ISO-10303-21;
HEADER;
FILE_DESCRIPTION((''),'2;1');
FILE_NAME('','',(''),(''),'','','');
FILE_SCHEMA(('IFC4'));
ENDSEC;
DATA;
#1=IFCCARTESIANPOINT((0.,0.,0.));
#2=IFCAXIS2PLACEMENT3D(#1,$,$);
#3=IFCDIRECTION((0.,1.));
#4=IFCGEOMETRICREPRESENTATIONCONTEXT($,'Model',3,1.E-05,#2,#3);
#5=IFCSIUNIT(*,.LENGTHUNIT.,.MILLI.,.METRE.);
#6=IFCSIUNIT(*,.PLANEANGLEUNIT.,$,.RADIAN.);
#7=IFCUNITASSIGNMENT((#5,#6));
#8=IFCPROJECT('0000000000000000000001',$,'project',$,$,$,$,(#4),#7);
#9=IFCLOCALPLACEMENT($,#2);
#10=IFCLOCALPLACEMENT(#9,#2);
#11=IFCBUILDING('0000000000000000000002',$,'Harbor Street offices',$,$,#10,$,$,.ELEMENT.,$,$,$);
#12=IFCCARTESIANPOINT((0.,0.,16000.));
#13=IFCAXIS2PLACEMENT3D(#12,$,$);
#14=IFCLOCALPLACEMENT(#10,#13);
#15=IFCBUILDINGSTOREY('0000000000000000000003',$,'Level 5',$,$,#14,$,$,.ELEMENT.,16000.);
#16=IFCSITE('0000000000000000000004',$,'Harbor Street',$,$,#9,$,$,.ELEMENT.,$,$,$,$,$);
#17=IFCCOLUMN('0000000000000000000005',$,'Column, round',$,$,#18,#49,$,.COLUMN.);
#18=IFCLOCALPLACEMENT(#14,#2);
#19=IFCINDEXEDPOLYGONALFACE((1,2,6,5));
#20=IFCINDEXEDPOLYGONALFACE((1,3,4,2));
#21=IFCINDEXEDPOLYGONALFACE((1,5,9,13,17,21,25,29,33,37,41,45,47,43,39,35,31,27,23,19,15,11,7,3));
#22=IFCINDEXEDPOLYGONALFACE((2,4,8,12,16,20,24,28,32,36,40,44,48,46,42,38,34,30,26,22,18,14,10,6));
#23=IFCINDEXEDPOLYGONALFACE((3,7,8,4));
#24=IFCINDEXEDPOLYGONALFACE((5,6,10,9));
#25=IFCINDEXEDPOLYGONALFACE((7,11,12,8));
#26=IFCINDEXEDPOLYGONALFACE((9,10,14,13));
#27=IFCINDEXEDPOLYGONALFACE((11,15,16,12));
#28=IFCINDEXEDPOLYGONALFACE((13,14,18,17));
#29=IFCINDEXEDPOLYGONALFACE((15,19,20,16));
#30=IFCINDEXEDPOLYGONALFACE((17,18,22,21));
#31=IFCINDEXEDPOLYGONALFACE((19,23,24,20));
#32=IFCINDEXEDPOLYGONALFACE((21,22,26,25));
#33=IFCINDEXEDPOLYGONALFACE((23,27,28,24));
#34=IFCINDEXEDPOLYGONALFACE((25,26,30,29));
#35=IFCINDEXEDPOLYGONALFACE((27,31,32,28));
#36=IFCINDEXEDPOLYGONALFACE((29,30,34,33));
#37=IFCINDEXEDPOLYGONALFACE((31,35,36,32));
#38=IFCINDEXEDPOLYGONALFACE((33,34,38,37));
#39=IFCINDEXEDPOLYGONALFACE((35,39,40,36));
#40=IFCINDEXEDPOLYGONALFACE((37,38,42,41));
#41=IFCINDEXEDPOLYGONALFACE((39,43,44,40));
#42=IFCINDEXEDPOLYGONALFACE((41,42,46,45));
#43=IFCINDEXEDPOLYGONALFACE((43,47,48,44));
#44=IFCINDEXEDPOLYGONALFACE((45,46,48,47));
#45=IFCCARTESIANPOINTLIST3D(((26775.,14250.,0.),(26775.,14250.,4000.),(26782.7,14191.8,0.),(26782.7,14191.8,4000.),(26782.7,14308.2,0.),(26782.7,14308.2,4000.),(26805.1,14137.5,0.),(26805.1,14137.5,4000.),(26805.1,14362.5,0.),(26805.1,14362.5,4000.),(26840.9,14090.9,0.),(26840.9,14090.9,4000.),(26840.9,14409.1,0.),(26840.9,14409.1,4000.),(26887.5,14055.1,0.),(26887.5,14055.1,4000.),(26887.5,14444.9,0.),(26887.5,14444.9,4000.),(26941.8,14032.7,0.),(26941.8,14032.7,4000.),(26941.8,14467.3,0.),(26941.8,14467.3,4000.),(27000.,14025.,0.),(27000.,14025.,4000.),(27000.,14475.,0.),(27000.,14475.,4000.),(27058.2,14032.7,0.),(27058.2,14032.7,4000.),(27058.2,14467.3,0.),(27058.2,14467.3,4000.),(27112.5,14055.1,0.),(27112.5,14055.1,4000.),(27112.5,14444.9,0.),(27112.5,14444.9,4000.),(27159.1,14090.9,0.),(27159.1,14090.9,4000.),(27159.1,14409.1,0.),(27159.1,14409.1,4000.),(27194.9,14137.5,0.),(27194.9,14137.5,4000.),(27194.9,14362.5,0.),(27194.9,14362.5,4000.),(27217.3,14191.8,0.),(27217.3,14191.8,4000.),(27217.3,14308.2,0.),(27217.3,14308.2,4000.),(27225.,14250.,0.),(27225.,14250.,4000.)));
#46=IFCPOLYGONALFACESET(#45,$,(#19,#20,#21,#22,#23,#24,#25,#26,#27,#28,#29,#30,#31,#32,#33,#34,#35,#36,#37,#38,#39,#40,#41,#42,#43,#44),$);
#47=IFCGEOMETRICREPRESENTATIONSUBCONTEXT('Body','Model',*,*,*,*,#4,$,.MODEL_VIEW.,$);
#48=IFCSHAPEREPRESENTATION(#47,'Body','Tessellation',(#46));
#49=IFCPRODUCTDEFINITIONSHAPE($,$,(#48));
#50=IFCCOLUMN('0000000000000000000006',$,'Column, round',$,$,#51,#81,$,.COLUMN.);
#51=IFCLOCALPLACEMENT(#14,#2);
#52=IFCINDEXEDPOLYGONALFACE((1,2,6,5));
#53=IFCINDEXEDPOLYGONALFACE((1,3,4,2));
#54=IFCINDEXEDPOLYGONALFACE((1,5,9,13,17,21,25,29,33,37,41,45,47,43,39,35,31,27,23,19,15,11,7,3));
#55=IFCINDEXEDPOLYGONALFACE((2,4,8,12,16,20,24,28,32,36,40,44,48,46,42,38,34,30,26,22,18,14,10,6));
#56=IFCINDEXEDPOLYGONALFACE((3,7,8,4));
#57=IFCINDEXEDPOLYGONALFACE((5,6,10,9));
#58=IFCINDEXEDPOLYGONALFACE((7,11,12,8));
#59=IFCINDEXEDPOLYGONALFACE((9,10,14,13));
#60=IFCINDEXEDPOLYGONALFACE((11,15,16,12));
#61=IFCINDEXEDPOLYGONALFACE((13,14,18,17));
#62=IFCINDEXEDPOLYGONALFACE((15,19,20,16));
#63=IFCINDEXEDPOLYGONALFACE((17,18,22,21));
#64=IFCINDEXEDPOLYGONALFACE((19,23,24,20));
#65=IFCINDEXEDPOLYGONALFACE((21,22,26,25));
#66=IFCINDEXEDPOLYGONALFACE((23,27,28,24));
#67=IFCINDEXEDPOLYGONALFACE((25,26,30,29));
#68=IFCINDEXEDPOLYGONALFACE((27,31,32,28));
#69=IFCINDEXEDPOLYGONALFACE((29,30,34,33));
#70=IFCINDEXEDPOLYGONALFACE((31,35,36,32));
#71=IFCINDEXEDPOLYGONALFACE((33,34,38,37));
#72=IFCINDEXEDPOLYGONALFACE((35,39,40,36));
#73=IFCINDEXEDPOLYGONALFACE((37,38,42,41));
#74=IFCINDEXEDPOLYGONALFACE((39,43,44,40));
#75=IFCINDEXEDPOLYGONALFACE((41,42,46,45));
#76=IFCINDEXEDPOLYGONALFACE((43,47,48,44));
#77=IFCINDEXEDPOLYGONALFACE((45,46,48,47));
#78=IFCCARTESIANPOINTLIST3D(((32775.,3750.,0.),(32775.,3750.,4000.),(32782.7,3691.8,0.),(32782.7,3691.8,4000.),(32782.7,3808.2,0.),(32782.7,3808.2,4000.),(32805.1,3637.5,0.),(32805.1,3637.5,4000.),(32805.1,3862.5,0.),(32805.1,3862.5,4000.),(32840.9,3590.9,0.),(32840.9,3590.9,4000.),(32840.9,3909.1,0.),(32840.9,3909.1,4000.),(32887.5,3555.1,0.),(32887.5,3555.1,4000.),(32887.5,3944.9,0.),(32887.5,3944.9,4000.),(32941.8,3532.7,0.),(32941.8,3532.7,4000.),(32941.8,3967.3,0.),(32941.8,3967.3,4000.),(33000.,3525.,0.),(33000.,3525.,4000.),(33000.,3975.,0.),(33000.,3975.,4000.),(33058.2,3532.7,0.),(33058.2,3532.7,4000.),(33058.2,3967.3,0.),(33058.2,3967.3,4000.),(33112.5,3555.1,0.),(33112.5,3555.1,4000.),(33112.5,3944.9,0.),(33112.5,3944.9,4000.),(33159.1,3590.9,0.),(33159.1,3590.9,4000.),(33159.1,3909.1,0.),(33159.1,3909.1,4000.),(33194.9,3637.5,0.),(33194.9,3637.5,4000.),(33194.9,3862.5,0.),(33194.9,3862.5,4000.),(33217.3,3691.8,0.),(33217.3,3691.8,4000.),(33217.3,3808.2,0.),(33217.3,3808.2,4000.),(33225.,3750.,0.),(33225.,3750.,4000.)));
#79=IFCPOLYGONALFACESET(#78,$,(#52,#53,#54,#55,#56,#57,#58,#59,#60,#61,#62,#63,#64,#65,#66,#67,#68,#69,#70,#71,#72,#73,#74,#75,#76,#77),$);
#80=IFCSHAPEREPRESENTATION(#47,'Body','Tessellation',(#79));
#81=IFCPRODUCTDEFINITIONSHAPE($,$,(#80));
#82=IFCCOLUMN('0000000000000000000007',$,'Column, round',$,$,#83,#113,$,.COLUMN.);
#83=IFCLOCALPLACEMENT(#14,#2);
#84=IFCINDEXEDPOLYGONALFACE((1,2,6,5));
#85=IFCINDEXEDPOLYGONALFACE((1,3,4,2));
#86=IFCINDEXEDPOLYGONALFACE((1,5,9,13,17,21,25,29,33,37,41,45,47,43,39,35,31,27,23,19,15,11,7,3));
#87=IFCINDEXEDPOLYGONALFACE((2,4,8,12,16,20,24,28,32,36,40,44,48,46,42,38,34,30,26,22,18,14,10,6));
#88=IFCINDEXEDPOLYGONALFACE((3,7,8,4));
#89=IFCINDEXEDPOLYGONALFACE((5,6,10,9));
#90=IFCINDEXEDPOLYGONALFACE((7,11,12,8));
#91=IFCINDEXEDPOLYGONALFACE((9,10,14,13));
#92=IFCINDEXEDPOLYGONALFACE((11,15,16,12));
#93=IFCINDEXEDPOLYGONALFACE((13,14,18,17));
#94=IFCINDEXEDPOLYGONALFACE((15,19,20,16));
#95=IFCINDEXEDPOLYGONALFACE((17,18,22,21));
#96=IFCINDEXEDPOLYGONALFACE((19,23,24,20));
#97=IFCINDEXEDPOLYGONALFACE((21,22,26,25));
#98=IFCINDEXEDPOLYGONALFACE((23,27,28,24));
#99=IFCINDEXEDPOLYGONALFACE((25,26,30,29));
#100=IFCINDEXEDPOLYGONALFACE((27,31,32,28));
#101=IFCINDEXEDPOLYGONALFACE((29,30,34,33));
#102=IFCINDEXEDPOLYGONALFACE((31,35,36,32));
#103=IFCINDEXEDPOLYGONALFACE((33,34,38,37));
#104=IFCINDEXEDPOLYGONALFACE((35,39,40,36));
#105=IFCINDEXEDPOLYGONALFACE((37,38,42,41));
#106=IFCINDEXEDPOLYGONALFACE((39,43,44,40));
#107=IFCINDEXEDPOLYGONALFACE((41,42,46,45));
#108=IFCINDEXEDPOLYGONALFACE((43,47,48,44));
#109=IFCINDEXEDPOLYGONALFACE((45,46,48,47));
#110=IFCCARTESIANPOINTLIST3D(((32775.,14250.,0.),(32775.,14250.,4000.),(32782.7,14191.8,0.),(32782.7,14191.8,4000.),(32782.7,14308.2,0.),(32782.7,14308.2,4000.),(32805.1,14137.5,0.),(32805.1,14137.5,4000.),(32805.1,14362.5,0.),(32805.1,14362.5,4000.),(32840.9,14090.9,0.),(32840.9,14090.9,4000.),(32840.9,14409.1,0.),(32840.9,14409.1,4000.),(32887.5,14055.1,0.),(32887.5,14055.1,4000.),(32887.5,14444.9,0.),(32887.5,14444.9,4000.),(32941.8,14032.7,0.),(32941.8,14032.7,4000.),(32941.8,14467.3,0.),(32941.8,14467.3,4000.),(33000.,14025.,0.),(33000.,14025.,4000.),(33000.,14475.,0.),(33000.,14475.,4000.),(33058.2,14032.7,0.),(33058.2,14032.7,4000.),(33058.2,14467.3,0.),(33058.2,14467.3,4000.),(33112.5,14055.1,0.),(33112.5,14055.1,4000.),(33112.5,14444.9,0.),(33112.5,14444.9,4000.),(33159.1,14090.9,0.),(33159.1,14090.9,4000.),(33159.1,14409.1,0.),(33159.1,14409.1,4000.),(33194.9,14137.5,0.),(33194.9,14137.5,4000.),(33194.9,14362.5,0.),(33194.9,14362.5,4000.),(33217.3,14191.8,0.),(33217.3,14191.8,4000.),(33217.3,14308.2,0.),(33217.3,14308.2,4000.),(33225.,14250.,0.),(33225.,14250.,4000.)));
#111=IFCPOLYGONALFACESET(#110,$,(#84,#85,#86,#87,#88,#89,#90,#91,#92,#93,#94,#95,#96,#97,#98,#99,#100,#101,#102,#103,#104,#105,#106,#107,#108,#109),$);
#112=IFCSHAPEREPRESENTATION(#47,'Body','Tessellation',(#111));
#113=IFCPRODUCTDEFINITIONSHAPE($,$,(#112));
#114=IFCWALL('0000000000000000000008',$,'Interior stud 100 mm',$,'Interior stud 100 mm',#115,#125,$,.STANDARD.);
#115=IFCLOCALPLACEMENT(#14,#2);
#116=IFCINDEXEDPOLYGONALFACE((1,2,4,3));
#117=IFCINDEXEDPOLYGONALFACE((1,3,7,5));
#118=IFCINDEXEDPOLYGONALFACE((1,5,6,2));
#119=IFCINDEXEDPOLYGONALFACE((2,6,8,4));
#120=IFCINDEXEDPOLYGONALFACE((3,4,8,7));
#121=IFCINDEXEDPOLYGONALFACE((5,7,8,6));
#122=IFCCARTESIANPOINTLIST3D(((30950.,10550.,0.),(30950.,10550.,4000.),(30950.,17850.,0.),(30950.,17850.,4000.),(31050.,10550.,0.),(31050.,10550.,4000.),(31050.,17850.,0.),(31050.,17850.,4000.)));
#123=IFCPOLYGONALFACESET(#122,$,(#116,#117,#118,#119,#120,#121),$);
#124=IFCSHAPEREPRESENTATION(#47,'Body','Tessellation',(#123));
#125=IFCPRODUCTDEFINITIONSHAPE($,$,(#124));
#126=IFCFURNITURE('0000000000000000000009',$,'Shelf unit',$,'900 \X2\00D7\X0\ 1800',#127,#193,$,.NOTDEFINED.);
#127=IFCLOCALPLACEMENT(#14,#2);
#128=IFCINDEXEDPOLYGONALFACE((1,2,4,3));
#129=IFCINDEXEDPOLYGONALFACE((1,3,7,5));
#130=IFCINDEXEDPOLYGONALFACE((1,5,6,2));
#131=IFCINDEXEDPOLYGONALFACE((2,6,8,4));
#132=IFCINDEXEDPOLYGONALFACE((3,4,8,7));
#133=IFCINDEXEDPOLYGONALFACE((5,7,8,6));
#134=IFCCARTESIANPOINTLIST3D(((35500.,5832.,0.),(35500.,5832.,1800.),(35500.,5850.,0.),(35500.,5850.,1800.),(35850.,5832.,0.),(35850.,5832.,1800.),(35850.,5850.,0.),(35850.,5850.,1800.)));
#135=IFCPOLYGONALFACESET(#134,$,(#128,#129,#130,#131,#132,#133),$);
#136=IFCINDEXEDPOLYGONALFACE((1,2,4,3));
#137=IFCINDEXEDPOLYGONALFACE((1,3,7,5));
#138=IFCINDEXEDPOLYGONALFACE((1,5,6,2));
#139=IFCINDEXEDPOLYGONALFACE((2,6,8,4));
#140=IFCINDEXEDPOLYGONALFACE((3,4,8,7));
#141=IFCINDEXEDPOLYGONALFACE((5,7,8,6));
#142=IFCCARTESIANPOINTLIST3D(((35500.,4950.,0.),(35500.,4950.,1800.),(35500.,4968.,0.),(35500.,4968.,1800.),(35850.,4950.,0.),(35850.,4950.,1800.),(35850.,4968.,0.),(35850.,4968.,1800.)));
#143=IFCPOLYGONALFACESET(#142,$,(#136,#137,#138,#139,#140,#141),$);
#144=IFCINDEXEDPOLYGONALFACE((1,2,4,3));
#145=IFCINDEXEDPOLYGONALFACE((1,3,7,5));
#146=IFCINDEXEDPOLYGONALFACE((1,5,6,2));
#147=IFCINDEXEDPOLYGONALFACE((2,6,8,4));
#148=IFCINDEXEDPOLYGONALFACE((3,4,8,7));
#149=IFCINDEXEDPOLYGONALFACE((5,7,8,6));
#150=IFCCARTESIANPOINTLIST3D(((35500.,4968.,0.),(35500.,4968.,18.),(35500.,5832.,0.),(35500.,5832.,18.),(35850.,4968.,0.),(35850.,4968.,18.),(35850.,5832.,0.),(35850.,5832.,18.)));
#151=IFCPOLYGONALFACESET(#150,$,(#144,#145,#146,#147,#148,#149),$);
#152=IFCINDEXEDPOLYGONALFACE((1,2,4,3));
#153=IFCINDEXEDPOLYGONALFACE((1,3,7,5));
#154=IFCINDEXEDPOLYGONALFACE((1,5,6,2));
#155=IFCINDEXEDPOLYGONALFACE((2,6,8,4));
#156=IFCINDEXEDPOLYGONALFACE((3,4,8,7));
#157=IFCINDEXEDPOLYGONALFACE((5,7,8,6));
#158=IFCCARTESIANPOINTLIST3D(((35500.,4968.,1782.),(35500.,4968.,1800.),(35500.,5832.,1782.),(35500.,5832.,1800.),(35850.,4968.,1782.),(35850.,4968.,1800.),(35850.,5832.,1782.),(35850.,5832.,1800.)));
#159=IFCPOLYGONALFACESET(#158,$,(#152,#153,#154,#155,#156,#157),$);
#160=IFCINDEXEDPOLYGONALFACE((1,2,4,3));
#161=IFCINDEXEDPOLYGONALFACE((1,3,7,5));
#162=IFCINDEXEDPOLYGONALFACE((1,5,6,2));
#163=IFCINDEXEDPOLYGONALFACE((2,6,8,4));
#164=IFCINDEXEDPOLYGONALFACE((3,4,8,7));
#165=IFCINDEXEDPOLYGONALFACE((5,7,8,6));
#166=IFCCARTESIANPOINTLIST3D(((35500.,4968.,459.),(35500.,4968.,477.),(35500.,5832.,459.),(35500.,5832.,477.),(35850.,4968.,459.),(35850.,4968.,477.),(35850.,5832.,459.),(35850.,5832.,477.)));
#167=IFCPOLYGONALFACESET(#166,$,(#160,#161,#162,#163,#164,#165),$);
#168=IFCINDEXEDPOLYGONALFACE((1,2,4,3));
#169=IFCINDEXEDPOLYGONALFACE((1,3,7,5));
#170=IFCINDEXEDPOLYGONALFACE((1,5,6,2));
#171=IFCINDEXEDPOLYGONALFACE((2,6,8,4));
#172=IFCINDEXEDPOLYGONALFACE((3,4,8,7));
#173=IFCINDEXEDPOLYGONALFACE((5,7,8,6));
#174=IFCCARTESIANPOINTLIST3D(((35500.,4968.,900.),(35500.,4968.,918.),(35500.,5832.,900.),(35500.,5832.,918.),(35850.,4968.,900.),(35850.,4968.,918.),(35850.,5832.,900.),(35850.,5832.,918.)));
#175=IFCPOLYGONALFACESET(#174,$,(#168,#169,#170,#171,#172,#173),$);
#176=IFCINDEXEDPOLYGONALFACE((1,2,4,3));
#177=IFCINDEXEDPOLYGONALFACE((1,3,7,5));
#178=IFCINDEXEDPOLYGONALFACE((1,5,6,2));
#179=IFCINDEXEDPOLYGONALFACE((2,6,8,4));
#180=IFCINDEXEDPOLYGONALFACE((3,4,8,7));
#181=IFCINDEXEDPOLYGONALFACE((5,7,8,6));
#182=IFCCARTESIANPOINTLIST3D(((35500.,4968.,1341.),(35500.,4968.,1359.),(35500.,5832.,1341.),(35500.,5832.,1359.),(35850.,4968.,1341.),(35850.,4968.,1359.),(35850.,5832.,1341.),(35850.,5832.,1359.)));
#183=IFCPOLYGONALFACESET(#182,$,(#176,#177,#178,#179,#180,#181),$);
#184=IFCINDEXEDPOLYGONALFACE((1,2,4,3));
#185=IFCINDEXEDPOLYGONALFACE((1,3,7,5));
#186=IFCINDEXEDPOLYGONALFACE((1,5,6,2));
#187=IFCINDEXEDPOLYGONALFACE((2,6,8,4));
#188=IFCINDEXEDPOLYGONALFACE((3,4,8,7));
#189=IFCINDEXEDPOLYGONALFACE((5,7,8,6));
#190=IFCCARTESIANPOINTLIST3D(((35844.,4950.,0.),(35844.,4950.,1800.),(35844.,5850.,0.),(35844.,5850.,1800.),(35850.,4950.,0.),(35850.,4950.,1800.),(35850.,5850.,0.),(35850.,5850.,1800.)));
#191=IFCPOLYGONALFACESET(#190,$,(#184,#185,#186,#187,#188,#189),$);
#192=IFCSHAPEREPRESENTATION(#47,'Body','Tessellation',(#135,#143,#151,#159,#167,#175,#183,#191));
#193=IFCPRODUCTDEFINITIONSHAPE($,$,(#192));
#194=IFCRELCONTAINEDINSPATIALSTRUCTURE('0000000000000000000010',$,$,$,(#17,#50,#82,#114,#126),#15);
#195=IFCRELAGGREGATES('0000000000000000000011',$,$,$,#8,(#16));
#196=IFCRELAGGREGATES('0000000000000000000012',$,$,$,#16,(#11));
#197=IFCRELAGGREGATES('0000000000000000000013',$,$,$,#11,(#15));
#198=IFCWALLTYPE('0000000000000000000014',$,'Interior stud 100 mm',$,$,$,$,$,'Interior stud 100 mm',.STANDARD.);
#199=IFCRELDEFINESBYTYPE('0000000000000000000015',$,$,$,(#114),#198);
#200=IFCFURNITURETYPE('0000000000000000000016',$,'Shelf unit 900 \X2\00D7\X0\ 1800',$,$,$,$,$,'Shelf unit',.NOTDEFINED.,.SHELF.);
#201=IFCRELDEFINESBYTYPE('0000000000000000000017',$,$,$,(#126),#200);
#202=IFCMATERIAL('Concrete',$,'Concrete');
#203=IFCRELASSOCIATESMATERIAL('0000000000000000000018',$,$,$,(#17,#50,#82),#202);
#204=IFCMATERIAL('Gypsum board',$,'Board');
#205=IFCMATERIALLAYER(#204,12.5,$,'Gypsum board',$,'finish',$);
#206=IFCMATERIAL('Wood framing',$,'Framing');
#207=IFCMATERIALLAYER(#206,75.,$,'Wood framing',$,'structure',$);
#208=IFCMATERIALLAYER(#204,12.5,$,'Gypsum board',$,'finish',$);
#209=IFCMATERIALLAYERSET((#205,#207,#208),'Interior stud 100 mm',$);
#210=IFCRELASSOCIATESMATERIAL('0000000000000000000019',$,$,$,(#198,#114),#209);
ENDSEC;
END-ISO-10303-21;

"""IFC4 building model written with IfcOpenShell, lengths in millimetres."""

from ifc_helpers import new_model, si_unit, direction, frame, origin, origin_2d, place, context, subcontext, project, spatial, polyline, circle, outline, extrude, source, transform, mapped, material, layer, layer_set, layer_usage, type_object, type_shapes, element, save


model = new_model("IFC4")

# Units and contexts
model_context = context("Model", 3, precision=1e-05, world=origin(), true_north=direction((0.0, 1.0)))
body_context = subcontext(model_context, "Body", "Model", "MODEL_VIEW")
ifc_project = project(units=[si_unit("LENGTHUNIT", "METRE", prefix="MILLI"), si_unit("PLANEANGLEUNIT", "RADIAN")], contexts=[model_context])

# Site, building, storey
site_placement = place(None, origin())
site = spatial("IfcSite", under=ifc_project, at=site_placement, Name="Harbor Street", CompositionType="ELEMENT")
building_placement = place(site_placement, origin())
building = spatial("IfcBuilding", under=site, at=building_placement, Name="Harbor Street offices", CompositionType="ELEMENT")
storey_placement = place(building_placement, frame((0.0, 0.0, 16000.0)))
storey = spatial("IfcBuildingStorey", under=building, at=storey_placement, Name="Level 5", CompositionType="ELEMENT", Elevation=16000.0)

# Columns
ifc_material_1 = material(Name="Concrete", Category="Concrete")
for number, where, z_axis, x_axis, name in (
    (1, (27000.0, 14250.0, 0.0), (0.0, 0.0, 1.0), (1.0, 0.0, 0.0), "Column, round"),
    (2, (33000.0, 3750.0, 0.0), (0.0, 0.0, 1.0), (1.0, 0.0, 0.0), "Column, round"),
    (3, (33000.0, 14250.0, 0.0), (0.0, 0.0, 1.0), (1.0, 0.0, 0.0), "Column, round"),
):
    element("IfcColumn", number, at=place(storey_placement, frame(where, z_axis=z_axis, x_axis=x_axis)), inside=storey, material=ifc_material_1, Name=name, PredefinedType="COLUMN", context=body_context, shape_type="SweptSolid", body=[
        extrude(circle(Radius=225.0, at=origin_2d()), origin(), (0.0, 0.0, 1.0), 4000.0),
    ])

# Wall
ifc_material_2 = material(Name="Gypsum board", Category="Board")
ifc_layer_1 = layer(ifc_material_2, 12.5, Name="Gypsum board", Category="finish")
ifc_material_3 = material(Name="Wood framing", Category="Framing")
ifc_layer_2 = layer(ifc_material_3, 75.0, Name="Wood framing", Category="structure")
ifc_layer_3 = layer(ifc_material_2, 12.5, Name="Gypsum board", Category="finish")
ifc_layer_set_1 = layer_set([ifc_layer_1, ifc_layer_2, ifc_layer_3], Name="Interior stud 100 mm")
ifc_layer_usage_1 = layer_usage(ifc_layer_set_1, "AXIS2", "NEGATIVE", 50.0)
wall_type_1 = type_object("IfcWallType", Name="Interior stud 100 mm", ElementType="Interior stud 100 mm", PredefinedType="STANDARD", material=ifc_layer_set_1)
wall_1_placement = place(storey_placement, frame((31000.0, 10500.0, 0.0), z_axis=(0.0, 0.0, 1.0), x_axis=(0.0, 1.0, 0.0)))
element("IfcWall", 4, at=wall_1_placement, inside=storey, type_object=wall_type_1, material=ifc_layer_usage_1, Name="Interior stud 100 mm", ObjectType="Interior stud 100 mm", PredefinedType="STANDARD", context=body_context, shape_type="SweptSolid", body=[
    extrude(outline(polyline([(50.0, -50.0), (7350.0, -50.0), (7350.0, 50.0), (50.0, 50.0), (50.0, -50.0)])), origin(), (0.0, 0.0, 1.0), 4000.0),
])

# Furniture
furniture_type_1 = type_object("IfcFurnitureType", Name="Shelf unit 900 × 1800", ElementType="Shelf unit", AssemblyPlace="NOTDEFINED", PredefinedType="SHELF")
shared_shape_1 = source(origin(), body_context, "Body", "SweptSolid", [
    extrude(outline(polyline([(-450.0, 0.0), (-432.0, 0.0), (-432.0, 350.0), (-450.0, 350.0), (-450.0, 0.0)])), origin(), (0.0, 0.0, 1.0), 1800.0),
    extrude(outline(polyline([(432.0, 0.0), (450.0, 0.0), (450.0, 350.0), (432.0, 350.0), (432.0, 0.0)])), origin(), (0.0, 0.0, 1.0), 1800.0),
    extrude(outline(polyline([(-432.0, 0.0), (432.0, 0.0), (432.0, 350.0), (-432.0, 350.0), (-432.0, 0.0)])), origin(), (0.0, 0.0, 1.0), 18.0),
    extrude(outline(polyline([(-432.0, 0.0), (432.0, 0.0), (432.0, 350.0), (-432.0, 350.0), (-432.0, 0.0)])), frame((0.0, 0.0, 1782.0)), (0.0, 0.0, 1.0), 18.0),
    extrude(outline(polyline([(-432.0, 0.0), (432.0, 0.0), (432.0, 350.0), (-432.0, 350.0), (-432.0, 0.0)])), frame((0.0, 0.0, 459.0)), (0.0, 0.0, 1.0), 18.0),
    extrude(outline(polyline([(-432.0, 0.0), (432.0, 0.0), (432.0, 350.0), (-432.0, 350.0), (-432.0, 0.0)])), frame((0.0, 0.0, 900.0)), (0.0, 0.0, 1.0), 18.0),
    extrude(outline(polyline([(-432.0, 0.0), (432.0, 0.0), (432.0, 350.0), (-432.0, 350.0), (-432.0, 0.0)])), frame((0.0, 0.0, 1341.0)), (0.0, 0.0, 1.0), 18.0),
    extrude(outline(polyline([(-450.0, 344.0), (450.0, 344.0), (450.0, 350.0), (-450.0, 350.0), (-450.0, 344.0)])), origin(), (0.0, 0.0, 1.0), 1800.0),
])
type_shapes(furniture_type_1, [shared_shape_1])
furniture_placement = place(storey_placement, frame((35500.0, 5400.0, 0.0), z_axis=(0.0, 0.0, 1.0), x_axis=(0.0, -1.0, 0.0)))
element("IfcFurniture", 5, at=furniture_placement, inside=storey, type_object=furniture_type_1, Name="Shelf unit", ObjectType="900 × 1800", PredefinedType="NOTDEFINED", context=body_context, shape_type="MappedRepresentation", body=[
    mapped(shared_shape_1, transform((0.0, 0.0, 0.0))),
])

save(model, "model.ifc")
